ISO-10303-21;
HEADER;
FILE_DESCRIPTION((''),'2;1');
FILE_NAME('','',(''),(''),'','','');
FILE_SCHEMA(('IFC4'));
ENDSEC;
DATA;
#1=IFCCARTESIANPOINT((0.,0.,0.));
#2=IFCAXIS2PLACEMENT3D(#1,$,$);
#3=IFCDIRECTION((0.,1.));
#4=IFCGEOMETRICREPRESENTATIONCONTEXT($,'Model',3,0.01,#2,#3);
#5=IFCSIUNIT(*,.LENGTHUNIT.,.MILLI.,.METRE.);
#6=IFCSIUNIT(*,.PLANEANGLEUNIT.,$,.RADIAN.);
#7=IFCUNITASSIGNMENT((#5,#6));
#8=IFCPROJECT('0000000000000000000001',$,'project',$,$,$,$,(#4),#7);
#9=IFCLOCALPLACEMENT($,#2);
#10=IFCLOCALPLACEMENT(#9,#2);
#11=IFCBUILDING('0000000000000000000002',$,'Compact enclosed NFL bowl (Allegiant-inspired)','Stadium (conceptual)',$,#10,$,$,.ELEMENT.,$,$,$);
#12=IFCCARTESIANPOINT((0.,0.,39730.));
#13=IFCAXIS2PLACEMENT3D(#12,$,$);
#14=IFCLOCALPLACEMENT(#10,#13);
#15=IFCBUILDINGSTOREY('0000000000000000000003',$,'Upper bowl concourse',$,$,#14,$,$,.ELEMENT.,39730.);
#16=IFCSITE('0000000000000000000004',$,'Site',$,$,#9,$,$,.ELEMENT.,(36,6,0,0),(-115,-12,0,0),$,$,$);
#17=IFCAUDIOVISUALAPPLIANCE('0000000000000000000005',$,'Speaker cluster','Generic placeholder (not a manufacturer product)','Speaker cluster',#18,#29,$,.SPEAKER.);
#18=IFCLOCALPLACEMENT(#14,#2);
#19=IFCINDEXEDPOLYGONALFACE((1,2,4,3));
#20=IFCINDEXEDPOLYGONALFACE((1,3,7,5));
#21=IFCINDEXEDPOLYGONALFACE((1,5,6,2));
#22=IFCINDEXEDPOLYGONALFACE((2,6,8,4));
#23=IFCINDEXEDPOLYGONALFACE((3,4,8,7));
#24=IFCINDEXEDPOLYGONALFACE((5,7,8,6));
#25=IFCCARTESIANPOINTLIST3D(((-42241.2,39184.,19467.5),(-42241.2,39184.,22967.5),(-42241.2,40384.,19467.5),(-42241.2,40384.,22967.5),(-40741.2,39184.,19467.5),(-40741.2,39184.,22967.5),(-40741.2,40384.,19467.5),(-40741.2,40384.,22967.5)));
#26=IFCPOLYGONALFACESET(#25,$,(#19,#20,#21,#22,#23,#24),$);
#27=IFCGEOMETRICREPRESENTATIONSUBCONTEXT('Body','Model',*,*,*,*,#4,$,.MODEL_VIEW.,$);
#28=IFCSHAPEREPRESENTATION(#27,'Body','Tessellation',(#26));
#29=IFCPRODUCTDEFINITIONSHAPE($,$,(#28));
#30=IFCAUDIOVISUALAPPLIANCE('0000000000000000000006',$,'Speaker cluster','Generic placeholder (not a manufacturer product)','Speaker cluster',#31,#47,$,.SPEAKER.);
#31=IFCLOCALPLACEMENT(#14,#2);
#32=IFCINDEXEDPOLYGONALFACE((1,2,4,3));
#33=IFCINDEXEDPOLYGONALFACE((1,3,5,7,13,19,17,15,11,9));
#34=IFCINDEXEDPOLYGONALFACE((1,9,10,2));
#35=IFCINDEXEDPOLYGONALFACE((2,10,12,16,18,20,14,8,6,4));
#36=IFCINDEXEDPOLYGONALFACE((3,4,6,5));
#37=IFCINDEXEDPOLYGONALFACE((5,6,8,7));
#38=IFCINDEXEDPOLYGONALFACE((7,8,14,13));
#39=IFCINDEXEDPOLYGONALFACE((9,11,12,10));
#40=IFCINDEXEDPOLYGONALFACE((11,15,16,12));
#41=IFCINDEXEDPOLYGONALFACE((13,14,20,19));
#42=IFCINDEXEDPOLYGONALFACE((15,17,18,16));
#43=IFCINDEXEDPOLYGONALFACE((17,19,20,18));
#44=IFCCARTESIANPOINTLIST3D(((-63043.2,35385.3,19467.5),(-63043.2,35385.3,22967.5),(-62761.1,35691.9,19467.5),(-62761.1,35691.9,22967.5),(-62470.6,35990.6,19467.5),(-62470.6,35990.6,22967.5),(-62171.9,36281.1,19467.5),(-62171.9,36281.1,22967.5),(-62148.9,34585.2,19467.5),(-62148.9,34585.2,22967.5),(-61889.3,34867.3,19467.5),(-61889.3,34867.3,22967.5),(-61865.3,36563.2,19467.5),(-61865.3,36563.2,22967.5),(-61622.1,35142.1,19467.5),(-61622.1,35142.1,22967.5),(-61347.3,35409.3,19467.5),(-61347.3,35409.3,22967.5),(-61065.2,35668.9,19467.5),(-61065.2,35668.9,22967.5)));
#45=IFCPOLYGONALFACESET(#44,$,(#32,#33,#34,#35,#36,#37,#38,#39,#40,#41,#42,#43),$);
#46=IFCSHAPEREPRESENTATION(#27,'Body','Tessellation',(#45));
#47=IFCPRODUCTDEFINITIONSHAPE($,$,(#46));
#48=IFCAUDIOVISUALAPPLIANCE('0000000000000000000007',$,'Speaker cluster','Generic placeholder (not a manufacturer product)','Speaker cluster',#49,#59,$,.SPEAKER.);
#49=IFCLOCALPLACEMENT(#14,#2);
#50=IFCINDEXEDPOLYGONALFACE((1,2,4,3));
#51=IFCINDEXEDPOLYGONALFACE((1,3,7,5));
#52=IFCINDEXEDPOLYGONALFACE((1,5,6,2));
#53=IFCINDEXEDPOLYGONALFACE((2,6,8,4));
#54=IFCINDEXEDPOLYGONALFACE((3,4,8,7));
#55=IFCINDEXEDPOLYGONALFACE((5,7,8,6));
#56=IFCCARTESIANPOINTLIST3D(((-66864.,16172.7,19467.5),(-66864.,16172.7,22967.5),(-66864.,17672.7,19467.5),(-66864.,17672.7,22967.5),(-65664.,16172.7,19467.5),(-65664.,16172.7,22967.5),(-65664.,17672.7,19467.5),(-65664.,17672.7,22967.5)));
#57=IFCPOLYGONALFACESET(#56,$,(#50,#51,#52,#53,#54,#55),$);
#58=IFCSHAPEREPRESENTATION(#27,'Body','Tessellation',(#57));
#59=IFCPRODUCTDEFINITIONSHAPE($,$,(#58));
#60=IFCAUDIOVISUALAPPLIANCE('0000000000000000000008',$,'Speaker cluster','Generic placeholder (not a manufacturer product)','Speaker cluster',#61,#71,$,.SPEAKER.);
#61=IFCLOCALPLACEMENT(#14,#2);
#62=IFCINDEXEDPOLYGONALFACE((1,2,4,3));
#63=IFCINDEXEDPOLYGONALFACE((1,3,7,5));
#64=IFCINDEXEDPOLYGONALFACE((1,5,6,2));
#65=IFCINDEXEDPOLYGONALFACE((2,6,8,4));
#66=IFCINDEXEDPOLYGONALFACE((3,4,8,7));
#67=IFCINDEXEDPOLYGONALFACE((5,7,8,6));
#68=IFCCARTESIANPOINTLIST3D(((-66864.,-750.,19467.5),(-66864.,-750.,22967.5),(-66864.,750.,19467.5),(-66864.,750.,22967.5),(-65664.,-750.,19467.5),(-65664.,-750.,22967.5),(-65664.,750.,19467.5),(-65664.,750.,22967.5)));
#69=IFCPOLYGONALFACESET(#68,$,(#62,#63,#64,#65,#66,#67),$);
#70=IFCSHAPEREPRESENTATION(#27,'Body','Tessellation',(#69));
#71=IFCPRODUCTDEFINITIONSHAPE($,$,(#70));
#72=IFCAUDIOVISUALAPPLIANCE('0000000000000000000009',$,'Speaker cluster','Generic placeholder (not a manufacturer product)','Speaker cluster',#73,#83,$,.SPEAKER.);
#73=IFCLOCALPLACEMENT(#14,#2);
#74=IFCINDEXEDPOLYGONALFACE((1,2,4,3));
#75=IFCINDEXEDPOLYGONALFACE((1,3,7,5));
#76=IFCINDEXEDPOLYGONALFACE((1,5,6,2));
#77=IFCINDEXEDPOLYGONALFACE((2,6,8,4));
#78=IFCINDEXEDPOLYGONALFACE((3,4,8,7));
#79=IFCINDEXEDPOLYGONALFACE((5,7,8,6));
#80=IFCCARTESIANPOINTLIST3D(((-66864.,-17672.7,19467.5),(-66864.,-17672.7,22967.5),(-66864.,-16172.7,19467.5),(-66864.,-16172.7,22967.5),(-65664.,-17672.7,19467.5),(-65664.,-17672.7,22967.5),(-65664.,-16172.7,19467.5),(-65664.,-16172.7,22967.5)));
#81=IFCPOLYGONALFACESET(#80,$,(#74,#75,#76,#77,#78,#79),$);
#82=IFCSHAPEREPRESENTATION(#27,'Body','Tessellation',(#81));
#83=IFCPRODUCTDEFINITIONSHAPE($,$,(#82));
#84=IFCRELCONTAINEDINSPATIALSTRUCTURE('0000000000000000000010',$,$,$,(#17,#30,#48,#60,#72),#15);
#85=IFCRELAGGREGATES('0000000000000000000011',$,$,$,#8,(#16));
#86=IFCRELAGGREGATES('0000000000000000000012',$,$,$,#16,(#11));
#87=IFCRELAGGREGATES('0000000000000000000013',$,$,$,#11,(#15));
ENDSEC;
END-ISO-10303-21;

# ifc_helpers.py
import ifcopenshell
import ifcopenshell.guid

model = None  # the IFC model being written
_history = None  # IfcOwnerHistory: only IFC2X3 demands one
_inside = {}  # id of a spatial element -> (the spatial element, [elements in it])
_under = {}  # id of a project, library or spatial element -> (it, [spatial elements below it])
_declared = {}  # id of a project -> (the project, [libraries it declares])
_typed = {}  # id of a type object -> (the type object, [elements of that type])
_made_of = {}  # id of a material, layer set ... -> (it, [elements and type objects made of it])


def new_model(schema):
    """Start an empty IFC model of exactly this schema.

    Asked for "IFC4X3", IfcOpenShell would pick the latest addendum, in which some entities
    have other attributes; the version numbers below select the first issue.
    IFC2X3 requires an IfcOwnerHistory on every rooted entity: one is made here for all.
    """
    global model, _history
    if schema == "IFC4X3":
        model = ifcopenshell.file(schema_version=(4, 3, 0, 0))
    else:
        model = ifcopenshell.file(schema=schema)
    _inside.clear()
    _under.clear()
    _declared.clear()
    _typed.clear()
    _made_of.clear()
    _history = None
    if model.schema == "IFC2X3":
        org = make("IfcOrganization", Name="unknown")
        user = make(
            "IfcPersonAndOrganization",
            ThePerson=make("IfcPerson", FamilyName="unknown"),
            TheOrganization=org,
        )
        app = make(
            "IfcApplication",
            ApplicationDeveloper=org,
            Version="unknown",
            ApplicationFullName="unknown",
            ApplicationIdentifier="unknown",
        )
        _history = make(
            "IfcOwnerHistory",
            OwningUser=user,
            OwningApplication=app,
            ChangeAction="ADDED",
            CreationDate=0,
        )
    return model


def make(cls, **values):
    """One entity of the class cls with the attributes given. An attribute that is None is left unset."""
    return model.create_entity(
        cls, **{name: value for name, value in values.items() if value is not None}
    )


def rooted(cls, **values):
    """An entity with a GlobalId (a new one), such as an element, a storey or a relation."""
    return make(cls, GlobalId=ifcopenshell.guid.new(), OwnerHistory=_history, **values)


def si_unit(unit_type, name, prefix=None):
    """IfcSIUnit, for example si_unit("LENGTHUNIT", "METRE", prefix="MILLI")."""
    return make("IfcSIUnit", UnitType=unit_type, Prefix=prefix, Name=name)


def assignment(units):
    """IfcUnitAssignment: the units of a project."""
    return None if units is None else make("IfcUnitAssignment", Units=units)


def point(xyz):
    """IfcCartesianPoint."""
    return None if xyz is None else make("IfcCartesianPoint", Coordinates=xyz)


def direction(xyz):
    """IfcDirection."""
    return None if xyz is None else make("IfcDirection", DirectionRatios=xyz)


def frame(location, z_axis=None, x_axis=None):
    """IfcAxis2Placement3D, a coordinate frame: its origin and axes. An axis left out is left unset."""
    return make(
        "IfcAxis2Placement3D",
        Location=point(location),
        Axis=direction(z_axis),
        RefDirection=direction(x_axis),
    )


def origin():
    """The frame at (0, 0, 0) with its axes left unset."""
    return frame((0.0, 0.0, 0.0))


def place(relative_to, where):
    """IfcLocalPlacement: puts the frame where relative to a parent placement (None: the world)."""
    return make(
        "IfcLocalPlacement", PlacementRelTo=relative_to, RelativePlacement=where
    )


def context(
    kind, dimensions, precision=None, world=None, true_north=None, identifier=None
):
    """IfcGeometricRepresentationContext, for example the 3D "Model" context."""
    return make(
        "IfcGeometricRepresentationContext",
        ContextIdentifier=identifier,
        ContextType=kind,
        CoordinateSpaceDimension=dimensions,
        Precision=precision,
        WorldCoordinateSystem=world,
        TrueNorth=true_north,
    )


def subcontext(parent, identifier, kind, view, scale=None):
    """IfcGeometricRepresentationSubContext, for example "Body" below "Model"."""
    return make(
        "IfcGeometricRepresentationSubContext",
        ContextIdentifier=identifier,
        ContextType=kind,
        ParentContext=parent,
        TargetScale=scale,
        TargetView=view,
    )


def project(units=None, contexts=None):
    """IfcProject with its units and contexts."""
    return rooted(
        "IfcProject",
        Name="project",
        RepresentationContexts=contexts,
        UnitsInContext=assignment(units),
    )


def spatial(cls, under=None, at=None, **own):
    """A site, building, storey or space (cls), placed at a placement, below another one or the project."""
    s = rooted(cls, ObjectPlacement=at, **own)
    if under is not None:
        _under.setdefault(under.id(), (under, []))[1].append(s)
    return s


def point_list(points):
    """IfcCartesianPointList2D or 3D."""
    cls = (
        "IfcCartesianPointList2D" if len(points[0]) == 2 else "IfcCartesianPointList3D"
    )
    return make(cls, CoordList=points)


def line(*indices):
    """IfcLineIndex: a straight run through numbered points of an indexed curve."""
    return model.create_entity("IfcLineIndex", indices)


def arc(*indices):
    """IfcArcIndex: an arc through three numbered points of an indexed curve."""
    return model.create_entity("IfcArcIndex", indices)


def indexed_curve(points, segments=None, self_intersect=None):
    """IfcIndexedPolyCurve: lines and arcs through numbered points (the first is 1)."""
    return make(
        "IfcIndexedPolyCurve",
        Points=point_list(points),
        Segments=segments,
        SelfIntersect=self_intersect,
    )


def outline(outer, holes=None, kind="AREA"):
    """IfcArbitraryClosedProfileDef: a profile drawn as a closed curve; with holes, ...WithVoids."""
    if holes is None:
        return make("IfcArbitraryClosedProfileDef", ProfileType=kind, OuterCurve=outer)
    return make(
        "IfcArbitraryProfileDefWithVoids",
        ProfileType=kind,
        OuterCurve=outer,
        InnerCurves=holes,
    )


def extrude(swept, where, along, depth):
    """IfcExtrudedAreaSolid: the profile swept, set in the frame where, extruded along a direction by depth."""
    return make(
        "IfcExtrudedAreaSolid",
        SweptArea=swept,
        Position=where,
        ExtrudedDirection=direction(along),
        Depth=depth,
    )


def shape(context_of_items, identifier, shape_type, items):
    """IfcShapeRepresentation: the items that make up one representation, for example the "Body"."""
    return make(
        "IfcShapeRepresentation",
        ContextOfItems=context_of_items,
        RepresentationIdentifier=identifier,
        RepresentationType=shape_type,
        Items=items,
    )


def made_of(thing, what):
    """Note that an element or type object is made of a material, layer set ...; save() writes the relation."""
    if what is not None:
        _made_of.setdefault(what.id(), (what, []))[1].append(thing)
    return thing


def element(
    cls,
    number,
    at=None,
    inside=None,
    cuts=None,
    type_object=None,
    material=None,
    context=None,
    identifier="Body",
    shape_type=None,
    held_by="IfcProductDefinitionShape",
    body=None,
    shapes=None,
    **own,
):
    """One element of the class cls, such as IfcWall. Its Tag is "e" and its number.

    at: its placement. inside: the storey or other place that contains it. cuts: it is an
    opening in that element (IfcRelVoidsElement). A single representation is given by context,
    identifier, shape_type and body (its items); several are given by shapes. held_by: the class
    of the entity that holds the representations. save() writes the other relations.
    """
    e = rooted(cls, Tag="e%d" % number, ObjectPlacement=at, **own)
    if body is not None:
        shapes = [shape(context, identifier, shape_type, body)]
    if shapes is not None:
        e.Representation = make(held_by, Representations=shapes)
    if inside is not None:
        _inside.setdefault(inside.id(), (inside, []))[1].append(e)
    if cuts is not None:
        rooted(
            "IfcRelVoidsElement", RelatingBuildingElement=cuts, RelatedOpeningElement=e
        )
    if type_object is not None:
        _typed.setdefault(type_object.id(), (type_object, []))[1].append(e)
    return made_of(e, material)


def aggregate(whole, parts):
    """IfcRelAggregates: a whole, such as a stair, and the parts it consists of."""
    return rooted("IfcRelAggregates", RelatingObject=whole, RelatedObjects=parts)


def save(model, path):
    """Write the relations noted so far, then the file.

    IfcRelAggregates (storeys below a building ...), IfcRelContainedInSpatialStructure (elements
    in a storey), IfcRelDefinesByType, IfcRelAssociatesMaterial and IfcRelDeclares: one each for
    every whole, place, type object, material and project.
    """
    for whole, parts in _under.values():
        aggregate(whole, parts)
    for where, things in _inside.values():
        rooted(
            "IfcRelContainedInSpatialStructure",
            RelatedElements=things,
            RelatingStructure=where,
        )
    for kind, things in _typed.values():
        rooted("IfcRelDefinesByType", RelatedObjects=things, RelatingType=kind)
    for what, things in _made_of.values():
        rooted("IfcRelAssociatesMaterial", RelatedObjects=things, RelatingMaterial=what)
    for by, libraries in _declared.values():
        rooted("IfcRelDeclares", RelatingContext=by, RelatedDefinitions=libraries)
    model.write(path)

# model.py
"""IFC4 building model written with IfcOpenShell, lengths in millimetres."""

from ifc_helpers import new_model, si_unit, direction, frame, origin, place, context, subcontext, project, spatial, line, arc, indexed_curve, outline, extrude, element, save


model = new_model("IFC4")

# Units and contexts
model_context = context("Model", 3, precision=0.01, world=origin(), true_north=direction((0.0, 1.0)))
body_context = subcontext(model_context, "Body", "Model", "MODEL_VIEW")
ifc_project = project(units=[si_unit("LENGTHUNIT", "METRE", prefix="MILLI"), si_unit("PLANEANGLEUNIT", "RADIAN")], contexts=[model_context])

# Site, building, storey
site_placement = place(None, origin())
site = spatial("IfcSite", under=ifc_project, at=site_placement, Name="Site", CompositionType="ELEMENT", RefLatitude=(36, 6, 0, 0), RefLongitude=(-115, -12, 0, 0))
building_placement = place(site_placement, origin())
building = spatial("IfcBuilding", under=site, at=building_placement, Name="Compact enclosed NFL bowl (Allegiant-inspired)", Description="Stadium (conceptual)", CompositionType="ELEMENT")
storey_placement = place(building_placement, frame((0.0, 0.0, 39730.0)))
storey = spatial("IfcBuildingStorey", under=building, at=storey_placement, Name="Upper bowl concourse", CompositionType="ELEMENT", Elevation=39730.0)

# Audio visual appliances
placement = place(storey_placement, frame((0.0, 0.0, -39730.0)))
element("IfcAudioVisualAppliance", 1, at=placement, inside=storey, Name="Speaker cluster", Description="Generic placeholder (not a manufacturer product)", ObjectType="Speaker cluster", PredefinedType="SPEAKER", context=body_context, shape_type="SweptSolid", body=[
    extrude(outline(indexed_curve([(-40741.2, 39184.0), (-42241.2, 39184.0), (-42241.2, 40384.0), (-40741.2, 40384.0)], segments=[line(1, 2), line(2, 3), line(3, 4), line(4, 1)], self_intersect=False)), frame((0.0, 0.0, 59197.5)), (0.0, 0.0, 1.0), 3500.0),
])
element("IfcAudioVisualAppliance", 2, at=placement, inside=storey, Name="Speaker cluster", Description="Generic placeholder (not a manufacturer product)", ObjectType="Speaker cluster", PredefinedType="SPEAKER", context=body_context, shape_type="SweptSolid", body=[
    extrude(outline(indexed_curve([(-61065.2, 35668.9), (-61622.1, 35142.1), (-62148.9, 34585.2), (-63043.2, 35385.3), (-62470.6, 35990.6), (-61865.3, 36563.2)], segments=[arc(1, 2, 3), line(3, 4), arc(4, 5, 6), line(6, 1)], self_intersect=False)), frame((0.0, 0.0, 59197.5)), (0.0, 0.0, 1.0), 3500.0),
])
element("IfcAudioVisualAppliance", 3, at=placement, inside=storey, Name="Speaker cluster", Description="Generic placeholder (not a manufacturer product)", ObjectType="Speaker cluster", PredefinedType="SPEAKER", context=body_context, shape_type="SweptSolid", body=[
    extrude(outline(indexed_curve([(-65664.0, 17672.7), (-65664.0, 16172.7), (-66864.0, 16172.7), (-66864.0, 17672.7)], segments=[line(1, 2), line(2, 3), line(3, 4), line(4, 1)], self_intersect=False)), frame((0.0, 0.0, 59197.5)), (0.0, 0.0, 1.0), 3500.0),
])
element("IfcAudioVisualAppliance", 4, at=placement, inside=storey, Name="Speaker cluster", Description="Generic placeholder (not a manufacturer product)", ObjectType="Speaker cluster", PredefinedType="SPEAKER", context=body_context, shape_type="SweptSolid", body=[
    extrude(outline(indexed_curve([(-65664.0, 750.0), (-65664.0, -750.0), (-66864.0, -750.0), (-66864.0, 750.0)], segments=[line(1, 2), line(2, 3), line(3, 4), line(4, 1)], self_intersect=False)), frame((0.0, 0.0, 59197.5)), (0.0, 0.0, 1.0), 3500.0),
])
element("IfcAudioVisualAppliance", 5, at=placement, inside=storey, Name="Speaker cluster", Description="Generic placeholder (not a manufacturer product)", ObjectType="Speaker cluster", PredefinedType="SPEAKER", context=body_context, shape_type="SweptSolid", body=[
    extrude(outline(indexed_curve([(-65664.0, -16172.7), (-65664.0, -17672.7), (-66864.0, -17672.7), (-66864.0, -16172.7)], segments=[line(1, 2), line(2, 3), line(3, 4), line(4, 1)], self_intersect=False)), frame((0.0, 0.0, 59197.5)), (0.0, 0.0, 1.0), 3500.0),
])

save(model, "model.ifc")
